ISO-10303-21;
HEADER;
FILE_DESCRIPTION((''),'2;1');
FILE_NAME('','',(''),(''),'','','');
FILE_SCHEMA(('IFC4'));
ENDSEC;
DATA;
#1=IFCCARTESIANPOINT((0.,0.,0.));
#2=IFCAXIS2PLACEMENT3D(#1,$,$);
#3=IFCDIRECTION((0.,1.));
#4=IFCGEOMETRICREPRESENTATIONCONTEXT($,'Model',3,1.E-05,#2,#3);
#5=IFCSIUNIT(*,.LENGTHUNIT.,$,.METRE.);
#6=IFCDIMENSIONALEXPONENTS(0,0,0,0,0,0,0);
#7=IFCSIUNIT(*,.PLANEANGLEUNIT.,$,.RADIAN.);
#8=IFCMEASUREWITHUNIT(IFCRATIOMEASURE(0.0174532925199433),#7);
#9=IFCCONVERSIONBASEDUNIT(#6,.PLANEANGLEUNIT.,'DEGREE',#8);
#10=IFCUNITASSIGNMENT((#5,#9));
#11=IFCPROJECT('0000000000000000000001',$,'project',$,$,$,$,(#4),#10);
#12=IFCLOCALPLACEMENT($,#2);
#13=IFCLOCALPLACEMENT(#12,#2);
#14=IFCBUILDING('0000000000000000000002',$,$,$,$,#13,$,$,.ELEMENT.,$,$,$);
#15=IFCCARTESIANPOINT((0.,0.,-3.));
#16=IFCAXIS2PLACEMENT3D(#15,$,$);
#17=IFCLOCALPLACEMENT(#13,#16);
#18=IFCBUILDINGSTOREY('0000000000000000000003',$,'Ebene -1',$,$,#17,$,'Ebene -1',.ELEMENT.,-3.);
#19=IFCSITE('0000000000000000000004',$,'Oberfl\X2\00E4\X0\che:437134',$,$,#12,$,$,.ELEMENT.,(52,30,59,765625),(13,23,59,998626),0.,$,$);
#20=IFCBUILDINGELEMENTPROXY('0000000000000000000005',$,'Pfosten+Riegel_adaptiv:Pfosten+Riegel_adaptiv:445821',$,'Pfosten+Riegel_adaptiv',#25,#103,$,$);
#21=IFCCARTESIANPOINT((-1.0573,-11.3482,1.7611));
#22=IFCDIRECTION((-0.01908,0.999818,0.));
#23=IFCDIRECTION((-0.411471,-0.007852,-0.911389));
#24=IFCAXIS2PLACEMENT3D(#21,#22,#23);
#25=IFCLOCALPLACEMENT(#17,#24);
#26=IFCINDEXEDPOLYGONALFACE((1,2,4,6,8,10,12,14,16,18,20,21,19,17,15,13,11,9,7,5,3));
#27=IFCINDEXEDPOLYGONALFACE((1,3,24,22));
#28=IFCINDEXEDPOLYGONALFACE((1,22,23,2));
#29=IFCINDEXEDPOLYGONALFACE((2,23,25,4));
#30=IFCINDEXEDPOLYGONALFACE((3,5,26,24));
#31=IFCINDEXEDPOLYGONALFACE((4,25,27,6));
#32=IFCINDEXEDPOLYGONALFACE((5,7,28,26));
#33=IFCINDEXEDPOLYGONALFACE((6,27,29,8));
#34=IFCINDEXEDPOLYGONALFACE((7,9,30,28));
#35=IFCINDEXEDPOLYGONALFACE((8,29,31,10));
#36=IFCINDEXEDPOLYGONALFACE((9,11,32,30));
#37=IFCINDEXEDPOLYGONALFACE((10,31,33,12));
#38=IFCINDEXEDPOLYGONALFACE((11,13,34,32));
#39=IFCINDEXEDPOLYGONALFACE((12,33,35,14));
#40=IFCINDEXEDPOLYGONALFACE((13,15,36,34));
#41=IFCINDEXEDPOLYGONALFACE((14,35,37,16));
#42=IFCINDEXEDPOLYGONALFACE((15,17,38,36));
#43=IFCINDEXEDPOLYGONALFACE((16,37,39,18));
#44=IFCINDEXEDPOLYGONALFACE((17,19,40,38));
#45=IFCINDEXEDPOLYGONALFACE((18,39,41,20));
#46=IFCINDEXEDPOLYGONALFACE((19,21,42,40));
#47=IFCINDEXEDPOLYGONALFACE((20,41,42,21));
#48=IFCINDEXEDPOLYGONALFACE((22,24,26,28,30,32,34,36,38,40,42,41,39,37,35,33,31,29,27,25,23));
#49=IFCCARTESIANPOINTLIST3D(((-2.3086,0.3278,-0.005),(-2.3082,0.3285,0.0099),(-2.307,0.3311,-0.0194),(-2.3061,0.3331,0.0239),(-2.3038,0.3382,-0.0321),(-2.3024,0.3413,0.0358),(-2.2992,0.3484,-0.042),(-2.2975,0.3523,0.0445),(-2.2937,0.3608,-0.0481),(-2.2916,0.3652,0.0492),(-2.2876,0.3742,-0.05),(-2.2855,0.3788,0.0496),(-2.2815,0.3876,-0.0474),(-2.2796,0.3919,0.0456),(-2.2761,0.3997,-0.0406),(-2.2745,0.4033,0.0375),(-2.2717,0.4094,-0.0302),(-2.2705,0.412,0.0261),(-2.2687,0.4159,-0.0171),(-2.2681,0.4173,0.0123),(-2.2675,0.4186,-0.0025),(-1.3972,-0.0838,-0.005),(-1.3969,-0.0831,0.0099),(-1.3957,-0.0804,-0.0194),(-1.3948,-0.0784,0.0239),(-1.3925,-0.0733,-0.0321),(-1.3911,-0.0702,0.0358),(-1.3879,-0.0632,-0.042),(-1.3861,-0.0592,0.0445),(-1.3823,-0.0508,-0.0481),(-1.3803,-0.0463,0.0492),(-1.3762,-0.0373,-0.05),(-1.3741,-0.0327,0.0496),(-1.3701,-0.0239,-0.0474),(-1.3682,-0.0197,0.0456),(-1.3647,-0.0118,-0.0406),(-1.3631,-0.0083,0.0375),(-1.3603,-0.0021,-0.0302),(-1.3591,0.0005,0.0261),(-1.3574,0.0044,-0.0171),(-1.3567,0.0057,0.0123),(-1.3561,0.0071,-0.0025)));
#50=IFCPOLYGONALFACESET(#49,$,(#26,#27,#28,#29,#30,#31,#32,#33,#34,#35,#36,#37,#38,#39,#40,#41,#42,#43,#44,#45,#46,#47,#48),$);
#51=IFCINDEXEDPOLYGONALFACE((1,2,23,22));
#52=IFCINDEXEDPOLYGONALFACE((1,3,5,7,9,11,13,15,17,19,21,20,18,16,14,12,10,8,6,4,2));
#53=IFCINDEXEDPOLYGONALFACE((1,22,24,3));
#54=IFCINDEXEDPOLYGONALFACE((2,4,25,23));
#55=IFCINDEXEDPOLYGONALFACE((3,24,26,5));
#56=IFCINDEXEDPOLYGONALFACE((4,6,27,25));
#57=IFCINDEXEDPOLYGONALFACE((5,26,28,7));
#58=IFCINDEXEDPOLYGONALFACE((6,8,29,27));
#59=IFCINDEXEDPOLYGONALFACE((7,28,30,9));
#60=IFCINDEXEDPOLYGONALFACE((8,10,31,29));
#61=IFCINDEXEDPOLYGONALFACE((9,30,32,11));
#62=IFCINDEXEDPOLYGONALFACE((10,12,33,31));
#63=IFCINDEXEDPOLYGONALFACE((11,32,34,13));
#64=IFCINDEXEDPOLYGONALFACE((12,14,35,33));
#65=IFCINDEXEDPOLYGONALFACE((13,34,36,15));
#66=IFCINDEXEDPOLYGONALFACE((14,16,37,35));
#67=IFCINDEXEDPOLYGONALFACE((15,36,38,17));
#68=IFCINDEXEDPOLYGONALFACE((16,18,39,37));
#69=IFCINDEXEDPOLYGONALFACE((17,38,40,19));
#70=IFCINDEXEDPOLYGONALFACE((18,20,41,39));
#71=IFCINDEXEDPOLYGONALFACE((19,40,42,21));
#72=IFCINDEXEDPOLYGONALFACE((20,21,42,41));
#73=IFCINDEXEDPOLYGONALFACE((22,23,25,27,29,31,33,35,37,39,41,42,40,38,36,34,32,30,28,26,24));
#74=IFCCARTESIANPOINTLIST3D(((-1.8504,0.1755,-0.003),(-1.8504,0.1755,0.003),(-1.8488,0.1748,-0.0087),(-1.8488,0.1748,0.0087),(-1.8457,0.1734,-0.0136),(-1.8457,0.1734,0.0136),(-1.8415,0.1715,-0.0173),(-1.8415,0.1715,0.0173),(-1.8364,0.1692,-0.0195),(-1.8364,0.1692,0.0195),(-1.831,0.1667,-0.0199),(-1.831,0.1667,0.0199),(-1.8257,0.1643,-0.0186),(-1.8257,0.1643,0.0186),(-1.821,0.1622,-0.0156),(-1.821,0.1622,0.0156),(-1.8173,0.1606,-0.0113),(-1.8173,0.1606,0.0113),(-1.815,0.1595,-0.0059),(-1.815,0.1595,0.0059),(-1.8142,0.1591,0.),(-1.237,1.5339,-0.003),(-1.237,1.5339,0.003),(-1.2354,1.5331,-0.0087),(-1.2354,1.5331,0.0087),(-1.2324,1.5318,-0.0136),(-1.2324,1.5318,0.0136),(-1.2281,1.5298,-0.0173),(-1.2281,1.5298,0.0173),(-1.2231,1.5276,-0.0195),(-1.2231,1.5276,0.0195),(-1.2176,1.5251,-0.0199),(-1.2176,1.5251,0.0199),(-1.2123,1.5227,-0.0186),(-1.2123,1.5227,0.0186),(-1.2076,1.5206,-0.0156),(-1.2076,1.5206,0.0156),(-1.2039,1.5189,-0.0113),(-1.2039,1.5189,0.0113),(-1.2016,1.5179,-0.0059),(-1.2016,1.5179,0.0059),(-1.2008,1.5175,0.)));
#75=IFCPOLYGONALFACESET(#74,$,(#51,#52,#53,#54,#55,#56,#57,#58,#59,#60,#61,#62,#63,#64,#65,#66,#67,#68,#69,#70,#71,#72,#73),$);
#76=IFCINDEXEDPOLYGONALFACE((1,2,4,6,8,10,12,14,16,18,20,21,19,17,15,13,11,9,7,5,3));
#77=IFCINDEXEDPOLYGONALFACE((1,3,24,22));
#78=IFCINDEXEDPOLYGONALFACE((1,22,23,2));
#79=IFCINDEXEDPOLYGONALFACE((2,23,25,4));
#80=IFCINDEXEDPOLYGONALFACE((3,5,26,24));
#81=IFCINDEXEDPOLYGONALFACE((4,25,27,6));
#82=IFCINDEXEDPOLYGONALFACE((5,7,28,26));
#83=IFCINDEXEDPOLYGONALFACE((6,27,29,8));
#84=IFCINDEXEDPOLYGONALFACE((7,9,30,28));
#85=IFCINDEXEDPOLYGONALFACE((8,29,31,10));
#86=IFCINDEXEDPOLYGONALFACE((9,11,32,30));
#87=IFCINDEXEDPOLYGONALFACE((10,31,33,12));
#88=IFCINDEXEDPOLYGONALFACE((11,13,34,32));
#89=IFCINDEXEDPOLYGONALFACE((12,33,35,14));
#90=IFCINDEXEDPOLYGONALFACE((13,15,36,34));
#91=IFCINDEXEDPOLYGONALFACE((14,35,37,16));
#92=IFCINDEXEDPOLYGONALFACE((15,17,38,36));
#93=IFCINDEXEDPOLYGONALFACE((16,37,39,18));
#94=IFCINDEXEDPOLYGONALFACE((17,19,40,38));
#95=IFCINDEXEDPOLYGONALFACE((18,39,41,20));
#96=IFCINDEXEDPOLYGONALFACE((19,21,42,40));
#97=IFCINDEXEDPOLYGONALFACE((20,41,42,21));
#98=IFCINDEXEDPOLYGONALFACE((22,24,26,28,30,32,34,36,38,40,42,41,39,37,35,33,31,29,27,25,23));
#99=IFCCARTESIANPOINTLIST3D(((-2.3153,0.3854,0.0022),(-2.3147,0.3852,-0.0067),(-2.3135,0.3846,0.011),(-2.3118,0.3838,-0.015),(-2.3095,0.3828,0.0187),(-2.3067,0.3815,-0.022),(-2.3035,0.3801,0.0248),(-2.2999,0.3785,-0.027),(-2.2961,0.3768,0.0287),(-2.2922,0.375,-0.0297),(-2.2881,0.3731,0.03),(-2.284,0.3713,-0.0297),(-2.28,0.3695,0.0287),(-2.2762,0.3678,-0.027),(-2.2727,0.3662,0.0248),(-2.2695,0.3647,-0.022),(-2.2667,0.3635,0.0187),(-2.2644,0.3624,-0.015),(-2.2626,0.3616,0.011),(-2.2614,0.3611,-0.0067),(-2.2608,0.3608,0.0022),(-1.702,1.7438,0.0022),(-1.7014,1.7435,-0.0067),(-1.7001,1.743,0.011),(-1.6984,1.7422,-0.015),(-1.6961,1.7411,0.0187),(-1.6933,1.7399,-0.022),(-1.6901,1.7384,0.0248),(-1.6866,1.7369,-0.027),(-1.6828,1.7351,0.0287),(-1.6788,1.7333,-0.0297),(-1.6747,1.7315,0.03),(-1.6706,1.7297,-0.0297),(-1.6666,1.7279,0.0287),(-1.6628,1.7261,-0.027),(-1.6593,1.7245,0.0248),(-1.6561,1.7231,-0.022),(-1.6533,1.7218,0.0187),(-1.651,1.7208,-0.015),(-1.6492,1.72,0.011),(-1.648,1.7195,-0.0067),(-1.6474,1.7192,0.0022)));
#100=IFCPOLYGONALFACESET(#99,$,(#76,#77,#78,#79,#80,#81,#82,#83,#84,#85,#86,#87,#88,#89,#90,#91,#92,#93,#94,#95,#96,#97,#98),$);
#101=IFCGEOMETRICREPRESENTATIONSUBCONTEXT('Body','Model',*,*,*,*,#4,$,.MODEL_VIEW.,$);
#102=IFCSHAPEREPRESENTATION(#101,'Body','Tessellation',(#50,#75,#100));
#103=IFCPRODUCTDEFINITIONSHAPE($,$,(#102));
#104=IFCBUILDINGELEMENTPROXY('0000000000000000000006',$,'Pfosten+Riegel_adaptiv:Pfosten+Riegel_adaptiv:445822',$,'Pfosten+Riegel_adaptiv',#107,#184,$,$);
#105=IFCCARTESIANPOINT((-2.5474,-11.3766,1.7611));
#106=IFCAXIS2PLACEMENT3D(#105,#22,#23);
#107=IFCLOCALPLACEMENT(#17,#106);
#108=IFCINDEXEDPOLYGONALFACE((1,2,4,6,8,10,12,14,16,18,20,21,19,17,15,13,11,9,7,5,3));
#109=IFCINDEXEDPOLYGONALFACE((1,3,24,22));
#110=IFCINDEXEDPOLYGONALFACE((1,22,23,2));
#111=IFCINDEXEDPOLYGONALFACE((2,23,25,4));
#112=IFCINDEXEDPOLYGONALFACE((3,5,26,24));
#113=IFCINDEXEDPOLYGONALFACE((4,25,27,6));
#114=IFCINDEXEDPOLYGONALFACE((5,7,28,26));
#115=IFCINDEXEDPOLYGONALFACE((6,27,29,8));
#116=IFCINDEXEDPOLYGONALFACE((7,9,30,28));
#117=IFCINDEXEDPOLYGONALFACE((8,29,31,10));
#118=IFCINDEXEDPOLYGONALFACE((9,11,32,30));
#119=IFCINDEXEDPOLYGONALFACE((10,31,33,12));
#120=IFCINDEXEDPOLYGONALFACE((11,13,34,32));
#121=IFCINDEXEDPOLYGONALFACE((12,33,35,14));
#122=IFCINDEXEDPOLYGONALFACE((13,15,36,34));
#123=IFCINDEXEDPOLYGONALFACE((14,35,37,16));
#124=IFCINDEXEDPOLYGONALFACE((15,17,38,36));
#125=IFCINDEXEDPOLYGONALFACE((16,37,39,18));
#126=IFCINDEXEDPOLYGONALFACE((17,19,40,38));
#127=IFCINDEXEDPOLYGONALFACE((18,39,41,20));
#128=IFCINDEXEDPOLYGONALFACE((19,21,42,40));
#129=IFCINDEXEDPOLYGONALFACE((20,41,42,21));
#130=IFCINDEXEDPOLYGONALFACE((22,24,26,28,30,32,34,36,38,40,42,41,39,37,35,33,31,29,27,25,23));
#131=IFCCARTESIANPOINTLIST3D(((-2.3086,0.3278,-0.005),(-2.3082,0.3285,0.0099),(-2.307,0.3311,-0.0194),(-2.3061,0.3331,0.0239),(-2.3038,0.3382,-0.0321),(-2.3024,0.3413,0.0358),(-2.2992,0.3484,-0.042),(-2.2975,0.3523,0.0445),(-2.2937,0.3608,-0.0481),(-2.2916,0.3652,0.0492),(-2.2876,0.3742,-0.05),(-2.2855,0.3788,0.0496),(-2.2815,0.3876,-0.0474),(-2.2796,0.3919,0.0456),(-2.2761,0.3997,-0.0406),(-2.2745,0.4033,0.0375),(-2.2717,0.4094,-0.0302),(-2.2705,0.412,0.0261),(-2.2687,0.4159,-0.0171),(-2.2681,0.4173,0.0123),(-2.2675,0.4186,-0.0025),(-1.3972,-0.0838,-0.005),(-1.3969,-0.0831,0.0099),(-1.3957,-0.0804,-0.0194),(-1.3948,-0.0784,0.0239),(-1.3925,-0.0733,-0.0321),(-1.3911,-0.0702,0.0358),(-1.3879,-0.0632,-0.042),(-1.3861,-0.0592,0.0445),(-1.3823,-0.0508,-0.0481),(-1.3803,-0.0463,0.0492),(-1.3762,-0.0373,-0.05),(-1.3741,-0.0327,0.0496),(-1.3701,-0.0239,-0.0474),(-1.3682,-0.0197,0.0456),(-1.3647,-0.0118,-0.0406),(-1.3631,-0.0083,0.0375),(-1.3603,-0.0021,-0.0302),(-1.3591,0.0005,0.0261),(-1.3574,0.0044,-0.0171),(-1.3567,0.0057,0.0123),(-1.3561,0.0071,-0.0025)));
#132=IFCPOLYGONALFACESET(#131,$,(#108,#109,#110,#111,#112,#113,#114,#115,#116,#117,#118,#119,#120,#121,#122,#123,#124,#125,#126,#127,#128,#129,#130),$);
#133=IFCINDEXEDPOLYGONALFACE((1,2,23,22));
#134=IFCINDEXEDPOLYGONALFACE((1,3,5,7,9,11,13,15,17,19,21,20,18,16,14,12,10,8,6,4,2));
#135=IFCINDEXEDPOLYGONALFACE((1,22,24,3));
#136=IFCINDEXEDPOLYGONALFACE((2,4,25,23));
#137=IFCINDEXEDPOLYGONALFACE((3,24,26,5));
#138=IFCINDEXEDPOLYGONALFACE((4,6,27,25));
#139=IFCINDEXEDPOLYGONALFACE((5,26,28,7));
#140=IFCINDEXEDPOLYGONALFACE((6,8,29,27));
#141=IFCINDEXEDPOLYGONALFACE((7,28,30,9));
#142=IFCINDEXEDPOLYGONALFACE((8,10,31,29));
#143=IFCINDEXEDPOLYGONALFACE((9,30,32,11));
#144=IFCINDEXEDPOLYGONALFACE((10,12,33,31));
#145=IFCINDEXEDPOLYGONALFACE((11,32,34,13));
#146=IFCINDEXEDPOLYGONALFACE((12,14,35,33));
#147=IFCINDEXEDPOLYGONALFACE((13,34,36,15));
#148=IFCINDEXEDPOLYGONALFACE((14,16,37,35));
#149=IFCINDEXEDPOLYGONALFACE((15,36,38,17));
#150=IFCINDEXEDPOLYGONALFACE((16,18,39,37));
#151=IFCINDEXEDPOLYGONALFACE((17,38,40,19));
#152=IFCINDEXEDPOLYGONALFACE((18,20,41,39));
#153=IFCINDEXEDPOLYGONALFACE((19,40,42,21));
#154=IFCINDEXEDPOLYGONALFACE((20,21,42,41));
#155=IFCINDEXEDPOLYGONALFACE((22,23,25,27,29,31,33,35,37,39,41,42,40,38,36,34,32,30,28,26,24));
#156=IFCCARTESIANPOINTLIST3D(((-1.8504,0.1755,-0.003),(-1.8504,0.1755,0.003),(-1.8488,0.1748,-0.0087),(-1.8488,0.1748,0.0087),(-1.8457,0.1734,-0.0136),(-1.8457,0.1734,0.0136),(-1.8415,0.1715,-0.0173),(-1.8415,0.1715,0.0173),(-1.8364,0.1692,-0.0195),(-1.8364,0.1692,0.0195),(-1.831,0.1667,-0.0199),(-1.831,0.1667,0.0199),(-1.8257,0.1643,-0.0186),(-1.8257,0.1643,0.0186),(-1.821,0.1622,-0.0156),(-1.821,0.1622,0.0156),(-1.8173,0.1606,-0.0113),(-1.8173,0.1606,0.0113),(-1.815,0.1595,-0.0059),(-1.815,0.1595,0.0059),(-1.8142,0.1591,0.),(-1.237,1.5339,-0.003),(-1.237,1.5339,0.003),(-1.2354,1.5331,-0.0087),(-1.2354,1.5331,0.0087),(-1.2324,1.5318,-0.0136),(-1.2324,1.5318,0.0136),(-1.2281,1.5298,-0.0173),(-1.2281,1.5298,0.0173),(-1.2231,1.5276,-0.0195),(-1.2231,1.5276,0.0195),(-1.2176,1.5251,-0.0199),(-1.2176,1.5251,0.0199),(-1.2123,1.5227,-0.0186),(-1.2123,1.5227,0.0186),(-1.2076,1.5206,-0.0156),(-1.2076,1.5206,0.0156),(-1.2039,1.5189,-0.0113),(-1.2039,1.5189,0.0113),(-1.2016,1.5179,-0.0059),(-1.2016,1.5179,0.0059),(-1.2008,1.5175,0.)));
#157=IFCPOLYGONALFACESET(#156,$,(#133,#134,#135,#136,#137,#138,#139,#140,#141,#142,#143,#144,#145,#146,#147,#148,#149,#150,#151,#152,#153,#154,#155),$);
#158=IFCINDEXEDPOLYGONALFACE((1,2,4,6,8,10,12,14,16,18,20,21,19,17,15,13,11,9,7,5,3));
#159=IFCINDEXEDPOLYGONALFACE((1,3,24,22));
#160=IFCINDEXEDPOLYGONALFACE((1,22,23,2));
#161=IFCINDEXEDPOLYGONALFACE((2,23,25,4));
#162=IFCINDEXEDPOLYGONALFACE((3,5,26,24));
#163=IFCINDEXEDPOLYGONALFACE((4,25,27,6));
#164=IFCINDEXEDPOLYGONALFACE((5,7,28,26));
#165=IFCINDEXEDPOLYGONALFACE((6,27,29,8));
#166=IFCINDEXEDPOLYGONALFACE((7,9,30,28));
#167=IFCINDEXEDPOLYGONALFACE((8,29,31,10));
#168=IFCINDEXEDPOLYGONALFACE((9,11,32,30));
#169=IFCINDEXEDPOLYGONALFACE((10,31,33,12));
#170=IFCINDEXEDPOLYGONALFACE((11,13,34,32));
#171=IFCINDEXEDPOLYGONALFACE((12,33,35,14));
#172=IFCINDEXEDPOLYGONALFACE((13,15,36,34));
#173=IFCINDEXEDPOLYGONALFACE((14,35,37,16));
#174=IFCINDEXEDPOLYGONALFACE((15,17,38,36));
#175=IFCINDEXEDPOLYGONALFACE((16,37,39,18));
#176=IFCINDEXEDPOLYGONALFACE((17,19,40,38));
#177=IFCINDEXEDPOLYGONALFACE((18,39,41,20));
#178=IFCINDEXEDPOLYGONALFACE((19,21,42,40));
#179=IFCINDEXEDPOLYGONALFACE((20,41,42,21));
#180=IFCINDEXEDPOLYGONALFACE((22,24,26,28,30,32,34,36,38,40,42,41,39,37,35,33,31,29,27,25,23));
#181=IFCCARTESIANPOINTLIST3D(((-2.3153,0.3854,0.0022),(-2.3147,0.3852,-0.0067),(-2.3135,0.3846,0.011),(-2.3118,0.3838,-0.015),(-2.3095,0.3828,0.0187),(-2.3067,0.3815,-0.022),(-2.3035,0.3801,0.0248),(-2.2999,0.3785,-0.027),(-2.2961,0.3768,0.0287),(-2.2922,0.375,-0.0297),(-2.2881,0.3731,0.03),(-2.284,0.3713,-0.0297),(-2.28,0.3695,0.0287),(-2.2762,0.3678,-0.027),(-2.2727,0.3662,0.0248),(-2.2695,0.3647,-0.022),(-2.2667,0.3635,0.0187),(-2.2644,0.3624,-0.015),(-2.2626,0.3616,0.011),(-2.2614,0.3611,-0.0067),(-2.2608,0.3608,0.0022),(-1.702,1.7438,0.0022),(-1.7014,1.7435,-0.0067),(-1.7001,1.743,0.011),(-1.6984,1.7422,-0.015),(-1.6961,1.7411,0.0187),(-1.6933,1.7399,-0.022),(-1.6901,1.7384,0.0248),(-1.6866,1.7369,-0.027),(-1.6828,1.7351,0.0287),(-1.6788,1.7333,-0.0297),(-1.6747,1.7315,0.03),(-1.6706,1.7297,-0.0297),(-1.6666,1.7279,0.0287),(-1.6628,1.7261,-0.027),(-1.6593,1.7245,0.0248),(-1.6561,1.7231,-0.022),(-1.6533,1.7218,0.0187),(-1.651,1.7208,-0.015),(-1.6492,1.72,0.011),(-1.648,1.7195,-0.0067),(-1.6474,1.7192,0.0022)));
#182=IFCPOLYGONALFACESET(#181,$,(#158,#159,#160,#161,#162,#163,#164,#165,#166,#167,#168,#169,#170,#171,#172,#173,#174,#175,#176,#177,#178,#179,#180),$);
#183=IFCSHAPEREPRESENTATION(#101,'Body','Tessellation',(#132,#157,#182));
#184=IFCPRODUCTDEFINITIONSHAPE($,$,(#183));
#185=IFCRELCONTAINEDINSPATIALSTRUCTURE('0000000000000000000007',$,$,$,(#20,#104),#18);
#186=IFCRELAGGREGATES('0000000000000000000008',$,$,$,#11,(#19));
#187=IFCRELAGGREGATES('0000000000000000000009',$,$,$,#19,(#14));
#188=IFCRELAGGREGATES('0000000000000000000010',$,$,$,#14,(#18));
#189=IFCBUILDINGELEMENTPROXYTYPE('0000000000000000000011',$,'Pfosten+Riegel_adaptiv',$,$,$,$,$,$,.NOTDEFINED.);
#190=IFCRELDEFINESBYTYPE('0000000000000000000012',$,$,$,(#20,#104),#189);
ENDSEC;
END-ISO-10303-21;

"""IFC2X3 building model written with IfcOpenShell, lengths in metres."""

from ifc_helpers import new_model, entity, si_unit, converted_unit, direction, frame, frame_2d, origin, place, context, subcontext, project, spatial, circle, extrude, source, transform, mapped, type_object, type_shapes, element, save


model = new_model("IFC2X3")

# Units and contexts
model_context = context("Model", 3, precision=1e-05, world=origin(), true_north=direction((0.0, 1.0)))
body_context = subcontext(model_context, "Body", "Model", "MODEL_VIEW")
ifc_project = project(units=[si_unit("LENGTHUNIT", "METRE"), converted_unit("PLANEANGLEUNIT", "DEGREE", entity("IfcRatioMeasure", 0.0174532925199433), si_unit("PLANEANGLEUNIT", "RADIAN"), dimensions=[0, 0, 0, 0, 0, 0, 0])], contexts=[model_context])

# Site, building, storey
site_placement = place(None, origin())
site = spatial("IfcSite", under=ifc_project, at=site_placement, Name="Oberfläche:437134", CompositionType="ELEMENT", RefLatitude=(52, 30, 59, 765625), RefLongitude=(13, 23, 59, 998626), RefElevation=0.0)
building_placement = place(site_placement, origin())
building = spatial("IfcBuilding", under=site, at=building_placement, CompositionType="ELEMENT")
storey_placement = place(building_placement, frame((0.0, 0.0, -3.0)))
storey = spatial("IfcBuildingStorey", under=building, at=storey_placement, Name="Ebene -1", LongName="Ebene -1", CompositionType="ELEMENT", Elevation=-3.0)

# Building element proxies
building_element_proxy_type_1 = type_object("IfcBuildingElementProxyType", Name="Pfosten+Riegel_adaptiv", PredefinedType="NOTDEFINED")
shared_shape_1 = source(origin(), body_context, "Body", "SweptSolid", [
    extrude(circle(Radius=0.05, at=frame_2d((0.0, 0.0), x_axis=(1.0, 0.0))), frame((-2.2881, 0.3731, 0.0), z_axis=(0.911389, -0.411546, 0.0), x_axis=(0.16937, 0.375078, 0.911389)), (0.0, 0.0, 1.0), 1.0),
    extrude(circle(Radius=0.02, at=frame_2d((0.0, 0.0), x_axis=(1.0, 0.0))), frame((-1.8324, 0.1674, 0.0), z_axis=(0.411546, 0.911389, 0.0), x_axis=(0.911389, -0.411546, 0.0)), (0.0, 0.0, 1.0), 1.4904),
    extrude(circle(Radius=0.03, at=frame_2d((0.0, 0.0), x_axis=(1.0, 0.0))), frame((-2.2881, 0.3731, 0.0), z_axis=(0.411546, 0.911389, 0.0), x_axis=(0.0, 0.0, 1.0)), (0.0, 0.0, 1.0), 1.4904),
])
type_shapes(building_element_proxy_type_1, [shared_shape_1])
for number, where, z_axis, x_axis, name in (
    (1, (-1.0573, -11.3482, 1.7611), (-0.01908, 0.999818, 0.0), (-0.411471, -0.007852, -0.911389), "Pfosten+Riegel_adaptiv:Pfosten+Riegel_adaptiv:445821"),
    (2, (-2.5474, -11.3766, 1.7611), (-0.01908, 0.999818, 0.0), (-0.411471, -0.007852, -0.911389), "Pfosten+Riegel_adaptiv:Pfosten+Riegel_adaptiv:445822"),
):
    element("IfcBuildingElementProxy", number, at=place(storey_placement, frame(where, z_axis=z_axis, x_axis=x_axis)), inside=storey, type_object=building_element_proxy_type_1, Name=name, ObjectType="Pfosten+Riegel_adaptiv", context=body_context, shape_type="MappedRepresentation", body=[
        mapped(shared_shape_1, transform((0.0, 0.0, 0.0), scale=1.0)),
    ])

save(model, "model.ifc")
